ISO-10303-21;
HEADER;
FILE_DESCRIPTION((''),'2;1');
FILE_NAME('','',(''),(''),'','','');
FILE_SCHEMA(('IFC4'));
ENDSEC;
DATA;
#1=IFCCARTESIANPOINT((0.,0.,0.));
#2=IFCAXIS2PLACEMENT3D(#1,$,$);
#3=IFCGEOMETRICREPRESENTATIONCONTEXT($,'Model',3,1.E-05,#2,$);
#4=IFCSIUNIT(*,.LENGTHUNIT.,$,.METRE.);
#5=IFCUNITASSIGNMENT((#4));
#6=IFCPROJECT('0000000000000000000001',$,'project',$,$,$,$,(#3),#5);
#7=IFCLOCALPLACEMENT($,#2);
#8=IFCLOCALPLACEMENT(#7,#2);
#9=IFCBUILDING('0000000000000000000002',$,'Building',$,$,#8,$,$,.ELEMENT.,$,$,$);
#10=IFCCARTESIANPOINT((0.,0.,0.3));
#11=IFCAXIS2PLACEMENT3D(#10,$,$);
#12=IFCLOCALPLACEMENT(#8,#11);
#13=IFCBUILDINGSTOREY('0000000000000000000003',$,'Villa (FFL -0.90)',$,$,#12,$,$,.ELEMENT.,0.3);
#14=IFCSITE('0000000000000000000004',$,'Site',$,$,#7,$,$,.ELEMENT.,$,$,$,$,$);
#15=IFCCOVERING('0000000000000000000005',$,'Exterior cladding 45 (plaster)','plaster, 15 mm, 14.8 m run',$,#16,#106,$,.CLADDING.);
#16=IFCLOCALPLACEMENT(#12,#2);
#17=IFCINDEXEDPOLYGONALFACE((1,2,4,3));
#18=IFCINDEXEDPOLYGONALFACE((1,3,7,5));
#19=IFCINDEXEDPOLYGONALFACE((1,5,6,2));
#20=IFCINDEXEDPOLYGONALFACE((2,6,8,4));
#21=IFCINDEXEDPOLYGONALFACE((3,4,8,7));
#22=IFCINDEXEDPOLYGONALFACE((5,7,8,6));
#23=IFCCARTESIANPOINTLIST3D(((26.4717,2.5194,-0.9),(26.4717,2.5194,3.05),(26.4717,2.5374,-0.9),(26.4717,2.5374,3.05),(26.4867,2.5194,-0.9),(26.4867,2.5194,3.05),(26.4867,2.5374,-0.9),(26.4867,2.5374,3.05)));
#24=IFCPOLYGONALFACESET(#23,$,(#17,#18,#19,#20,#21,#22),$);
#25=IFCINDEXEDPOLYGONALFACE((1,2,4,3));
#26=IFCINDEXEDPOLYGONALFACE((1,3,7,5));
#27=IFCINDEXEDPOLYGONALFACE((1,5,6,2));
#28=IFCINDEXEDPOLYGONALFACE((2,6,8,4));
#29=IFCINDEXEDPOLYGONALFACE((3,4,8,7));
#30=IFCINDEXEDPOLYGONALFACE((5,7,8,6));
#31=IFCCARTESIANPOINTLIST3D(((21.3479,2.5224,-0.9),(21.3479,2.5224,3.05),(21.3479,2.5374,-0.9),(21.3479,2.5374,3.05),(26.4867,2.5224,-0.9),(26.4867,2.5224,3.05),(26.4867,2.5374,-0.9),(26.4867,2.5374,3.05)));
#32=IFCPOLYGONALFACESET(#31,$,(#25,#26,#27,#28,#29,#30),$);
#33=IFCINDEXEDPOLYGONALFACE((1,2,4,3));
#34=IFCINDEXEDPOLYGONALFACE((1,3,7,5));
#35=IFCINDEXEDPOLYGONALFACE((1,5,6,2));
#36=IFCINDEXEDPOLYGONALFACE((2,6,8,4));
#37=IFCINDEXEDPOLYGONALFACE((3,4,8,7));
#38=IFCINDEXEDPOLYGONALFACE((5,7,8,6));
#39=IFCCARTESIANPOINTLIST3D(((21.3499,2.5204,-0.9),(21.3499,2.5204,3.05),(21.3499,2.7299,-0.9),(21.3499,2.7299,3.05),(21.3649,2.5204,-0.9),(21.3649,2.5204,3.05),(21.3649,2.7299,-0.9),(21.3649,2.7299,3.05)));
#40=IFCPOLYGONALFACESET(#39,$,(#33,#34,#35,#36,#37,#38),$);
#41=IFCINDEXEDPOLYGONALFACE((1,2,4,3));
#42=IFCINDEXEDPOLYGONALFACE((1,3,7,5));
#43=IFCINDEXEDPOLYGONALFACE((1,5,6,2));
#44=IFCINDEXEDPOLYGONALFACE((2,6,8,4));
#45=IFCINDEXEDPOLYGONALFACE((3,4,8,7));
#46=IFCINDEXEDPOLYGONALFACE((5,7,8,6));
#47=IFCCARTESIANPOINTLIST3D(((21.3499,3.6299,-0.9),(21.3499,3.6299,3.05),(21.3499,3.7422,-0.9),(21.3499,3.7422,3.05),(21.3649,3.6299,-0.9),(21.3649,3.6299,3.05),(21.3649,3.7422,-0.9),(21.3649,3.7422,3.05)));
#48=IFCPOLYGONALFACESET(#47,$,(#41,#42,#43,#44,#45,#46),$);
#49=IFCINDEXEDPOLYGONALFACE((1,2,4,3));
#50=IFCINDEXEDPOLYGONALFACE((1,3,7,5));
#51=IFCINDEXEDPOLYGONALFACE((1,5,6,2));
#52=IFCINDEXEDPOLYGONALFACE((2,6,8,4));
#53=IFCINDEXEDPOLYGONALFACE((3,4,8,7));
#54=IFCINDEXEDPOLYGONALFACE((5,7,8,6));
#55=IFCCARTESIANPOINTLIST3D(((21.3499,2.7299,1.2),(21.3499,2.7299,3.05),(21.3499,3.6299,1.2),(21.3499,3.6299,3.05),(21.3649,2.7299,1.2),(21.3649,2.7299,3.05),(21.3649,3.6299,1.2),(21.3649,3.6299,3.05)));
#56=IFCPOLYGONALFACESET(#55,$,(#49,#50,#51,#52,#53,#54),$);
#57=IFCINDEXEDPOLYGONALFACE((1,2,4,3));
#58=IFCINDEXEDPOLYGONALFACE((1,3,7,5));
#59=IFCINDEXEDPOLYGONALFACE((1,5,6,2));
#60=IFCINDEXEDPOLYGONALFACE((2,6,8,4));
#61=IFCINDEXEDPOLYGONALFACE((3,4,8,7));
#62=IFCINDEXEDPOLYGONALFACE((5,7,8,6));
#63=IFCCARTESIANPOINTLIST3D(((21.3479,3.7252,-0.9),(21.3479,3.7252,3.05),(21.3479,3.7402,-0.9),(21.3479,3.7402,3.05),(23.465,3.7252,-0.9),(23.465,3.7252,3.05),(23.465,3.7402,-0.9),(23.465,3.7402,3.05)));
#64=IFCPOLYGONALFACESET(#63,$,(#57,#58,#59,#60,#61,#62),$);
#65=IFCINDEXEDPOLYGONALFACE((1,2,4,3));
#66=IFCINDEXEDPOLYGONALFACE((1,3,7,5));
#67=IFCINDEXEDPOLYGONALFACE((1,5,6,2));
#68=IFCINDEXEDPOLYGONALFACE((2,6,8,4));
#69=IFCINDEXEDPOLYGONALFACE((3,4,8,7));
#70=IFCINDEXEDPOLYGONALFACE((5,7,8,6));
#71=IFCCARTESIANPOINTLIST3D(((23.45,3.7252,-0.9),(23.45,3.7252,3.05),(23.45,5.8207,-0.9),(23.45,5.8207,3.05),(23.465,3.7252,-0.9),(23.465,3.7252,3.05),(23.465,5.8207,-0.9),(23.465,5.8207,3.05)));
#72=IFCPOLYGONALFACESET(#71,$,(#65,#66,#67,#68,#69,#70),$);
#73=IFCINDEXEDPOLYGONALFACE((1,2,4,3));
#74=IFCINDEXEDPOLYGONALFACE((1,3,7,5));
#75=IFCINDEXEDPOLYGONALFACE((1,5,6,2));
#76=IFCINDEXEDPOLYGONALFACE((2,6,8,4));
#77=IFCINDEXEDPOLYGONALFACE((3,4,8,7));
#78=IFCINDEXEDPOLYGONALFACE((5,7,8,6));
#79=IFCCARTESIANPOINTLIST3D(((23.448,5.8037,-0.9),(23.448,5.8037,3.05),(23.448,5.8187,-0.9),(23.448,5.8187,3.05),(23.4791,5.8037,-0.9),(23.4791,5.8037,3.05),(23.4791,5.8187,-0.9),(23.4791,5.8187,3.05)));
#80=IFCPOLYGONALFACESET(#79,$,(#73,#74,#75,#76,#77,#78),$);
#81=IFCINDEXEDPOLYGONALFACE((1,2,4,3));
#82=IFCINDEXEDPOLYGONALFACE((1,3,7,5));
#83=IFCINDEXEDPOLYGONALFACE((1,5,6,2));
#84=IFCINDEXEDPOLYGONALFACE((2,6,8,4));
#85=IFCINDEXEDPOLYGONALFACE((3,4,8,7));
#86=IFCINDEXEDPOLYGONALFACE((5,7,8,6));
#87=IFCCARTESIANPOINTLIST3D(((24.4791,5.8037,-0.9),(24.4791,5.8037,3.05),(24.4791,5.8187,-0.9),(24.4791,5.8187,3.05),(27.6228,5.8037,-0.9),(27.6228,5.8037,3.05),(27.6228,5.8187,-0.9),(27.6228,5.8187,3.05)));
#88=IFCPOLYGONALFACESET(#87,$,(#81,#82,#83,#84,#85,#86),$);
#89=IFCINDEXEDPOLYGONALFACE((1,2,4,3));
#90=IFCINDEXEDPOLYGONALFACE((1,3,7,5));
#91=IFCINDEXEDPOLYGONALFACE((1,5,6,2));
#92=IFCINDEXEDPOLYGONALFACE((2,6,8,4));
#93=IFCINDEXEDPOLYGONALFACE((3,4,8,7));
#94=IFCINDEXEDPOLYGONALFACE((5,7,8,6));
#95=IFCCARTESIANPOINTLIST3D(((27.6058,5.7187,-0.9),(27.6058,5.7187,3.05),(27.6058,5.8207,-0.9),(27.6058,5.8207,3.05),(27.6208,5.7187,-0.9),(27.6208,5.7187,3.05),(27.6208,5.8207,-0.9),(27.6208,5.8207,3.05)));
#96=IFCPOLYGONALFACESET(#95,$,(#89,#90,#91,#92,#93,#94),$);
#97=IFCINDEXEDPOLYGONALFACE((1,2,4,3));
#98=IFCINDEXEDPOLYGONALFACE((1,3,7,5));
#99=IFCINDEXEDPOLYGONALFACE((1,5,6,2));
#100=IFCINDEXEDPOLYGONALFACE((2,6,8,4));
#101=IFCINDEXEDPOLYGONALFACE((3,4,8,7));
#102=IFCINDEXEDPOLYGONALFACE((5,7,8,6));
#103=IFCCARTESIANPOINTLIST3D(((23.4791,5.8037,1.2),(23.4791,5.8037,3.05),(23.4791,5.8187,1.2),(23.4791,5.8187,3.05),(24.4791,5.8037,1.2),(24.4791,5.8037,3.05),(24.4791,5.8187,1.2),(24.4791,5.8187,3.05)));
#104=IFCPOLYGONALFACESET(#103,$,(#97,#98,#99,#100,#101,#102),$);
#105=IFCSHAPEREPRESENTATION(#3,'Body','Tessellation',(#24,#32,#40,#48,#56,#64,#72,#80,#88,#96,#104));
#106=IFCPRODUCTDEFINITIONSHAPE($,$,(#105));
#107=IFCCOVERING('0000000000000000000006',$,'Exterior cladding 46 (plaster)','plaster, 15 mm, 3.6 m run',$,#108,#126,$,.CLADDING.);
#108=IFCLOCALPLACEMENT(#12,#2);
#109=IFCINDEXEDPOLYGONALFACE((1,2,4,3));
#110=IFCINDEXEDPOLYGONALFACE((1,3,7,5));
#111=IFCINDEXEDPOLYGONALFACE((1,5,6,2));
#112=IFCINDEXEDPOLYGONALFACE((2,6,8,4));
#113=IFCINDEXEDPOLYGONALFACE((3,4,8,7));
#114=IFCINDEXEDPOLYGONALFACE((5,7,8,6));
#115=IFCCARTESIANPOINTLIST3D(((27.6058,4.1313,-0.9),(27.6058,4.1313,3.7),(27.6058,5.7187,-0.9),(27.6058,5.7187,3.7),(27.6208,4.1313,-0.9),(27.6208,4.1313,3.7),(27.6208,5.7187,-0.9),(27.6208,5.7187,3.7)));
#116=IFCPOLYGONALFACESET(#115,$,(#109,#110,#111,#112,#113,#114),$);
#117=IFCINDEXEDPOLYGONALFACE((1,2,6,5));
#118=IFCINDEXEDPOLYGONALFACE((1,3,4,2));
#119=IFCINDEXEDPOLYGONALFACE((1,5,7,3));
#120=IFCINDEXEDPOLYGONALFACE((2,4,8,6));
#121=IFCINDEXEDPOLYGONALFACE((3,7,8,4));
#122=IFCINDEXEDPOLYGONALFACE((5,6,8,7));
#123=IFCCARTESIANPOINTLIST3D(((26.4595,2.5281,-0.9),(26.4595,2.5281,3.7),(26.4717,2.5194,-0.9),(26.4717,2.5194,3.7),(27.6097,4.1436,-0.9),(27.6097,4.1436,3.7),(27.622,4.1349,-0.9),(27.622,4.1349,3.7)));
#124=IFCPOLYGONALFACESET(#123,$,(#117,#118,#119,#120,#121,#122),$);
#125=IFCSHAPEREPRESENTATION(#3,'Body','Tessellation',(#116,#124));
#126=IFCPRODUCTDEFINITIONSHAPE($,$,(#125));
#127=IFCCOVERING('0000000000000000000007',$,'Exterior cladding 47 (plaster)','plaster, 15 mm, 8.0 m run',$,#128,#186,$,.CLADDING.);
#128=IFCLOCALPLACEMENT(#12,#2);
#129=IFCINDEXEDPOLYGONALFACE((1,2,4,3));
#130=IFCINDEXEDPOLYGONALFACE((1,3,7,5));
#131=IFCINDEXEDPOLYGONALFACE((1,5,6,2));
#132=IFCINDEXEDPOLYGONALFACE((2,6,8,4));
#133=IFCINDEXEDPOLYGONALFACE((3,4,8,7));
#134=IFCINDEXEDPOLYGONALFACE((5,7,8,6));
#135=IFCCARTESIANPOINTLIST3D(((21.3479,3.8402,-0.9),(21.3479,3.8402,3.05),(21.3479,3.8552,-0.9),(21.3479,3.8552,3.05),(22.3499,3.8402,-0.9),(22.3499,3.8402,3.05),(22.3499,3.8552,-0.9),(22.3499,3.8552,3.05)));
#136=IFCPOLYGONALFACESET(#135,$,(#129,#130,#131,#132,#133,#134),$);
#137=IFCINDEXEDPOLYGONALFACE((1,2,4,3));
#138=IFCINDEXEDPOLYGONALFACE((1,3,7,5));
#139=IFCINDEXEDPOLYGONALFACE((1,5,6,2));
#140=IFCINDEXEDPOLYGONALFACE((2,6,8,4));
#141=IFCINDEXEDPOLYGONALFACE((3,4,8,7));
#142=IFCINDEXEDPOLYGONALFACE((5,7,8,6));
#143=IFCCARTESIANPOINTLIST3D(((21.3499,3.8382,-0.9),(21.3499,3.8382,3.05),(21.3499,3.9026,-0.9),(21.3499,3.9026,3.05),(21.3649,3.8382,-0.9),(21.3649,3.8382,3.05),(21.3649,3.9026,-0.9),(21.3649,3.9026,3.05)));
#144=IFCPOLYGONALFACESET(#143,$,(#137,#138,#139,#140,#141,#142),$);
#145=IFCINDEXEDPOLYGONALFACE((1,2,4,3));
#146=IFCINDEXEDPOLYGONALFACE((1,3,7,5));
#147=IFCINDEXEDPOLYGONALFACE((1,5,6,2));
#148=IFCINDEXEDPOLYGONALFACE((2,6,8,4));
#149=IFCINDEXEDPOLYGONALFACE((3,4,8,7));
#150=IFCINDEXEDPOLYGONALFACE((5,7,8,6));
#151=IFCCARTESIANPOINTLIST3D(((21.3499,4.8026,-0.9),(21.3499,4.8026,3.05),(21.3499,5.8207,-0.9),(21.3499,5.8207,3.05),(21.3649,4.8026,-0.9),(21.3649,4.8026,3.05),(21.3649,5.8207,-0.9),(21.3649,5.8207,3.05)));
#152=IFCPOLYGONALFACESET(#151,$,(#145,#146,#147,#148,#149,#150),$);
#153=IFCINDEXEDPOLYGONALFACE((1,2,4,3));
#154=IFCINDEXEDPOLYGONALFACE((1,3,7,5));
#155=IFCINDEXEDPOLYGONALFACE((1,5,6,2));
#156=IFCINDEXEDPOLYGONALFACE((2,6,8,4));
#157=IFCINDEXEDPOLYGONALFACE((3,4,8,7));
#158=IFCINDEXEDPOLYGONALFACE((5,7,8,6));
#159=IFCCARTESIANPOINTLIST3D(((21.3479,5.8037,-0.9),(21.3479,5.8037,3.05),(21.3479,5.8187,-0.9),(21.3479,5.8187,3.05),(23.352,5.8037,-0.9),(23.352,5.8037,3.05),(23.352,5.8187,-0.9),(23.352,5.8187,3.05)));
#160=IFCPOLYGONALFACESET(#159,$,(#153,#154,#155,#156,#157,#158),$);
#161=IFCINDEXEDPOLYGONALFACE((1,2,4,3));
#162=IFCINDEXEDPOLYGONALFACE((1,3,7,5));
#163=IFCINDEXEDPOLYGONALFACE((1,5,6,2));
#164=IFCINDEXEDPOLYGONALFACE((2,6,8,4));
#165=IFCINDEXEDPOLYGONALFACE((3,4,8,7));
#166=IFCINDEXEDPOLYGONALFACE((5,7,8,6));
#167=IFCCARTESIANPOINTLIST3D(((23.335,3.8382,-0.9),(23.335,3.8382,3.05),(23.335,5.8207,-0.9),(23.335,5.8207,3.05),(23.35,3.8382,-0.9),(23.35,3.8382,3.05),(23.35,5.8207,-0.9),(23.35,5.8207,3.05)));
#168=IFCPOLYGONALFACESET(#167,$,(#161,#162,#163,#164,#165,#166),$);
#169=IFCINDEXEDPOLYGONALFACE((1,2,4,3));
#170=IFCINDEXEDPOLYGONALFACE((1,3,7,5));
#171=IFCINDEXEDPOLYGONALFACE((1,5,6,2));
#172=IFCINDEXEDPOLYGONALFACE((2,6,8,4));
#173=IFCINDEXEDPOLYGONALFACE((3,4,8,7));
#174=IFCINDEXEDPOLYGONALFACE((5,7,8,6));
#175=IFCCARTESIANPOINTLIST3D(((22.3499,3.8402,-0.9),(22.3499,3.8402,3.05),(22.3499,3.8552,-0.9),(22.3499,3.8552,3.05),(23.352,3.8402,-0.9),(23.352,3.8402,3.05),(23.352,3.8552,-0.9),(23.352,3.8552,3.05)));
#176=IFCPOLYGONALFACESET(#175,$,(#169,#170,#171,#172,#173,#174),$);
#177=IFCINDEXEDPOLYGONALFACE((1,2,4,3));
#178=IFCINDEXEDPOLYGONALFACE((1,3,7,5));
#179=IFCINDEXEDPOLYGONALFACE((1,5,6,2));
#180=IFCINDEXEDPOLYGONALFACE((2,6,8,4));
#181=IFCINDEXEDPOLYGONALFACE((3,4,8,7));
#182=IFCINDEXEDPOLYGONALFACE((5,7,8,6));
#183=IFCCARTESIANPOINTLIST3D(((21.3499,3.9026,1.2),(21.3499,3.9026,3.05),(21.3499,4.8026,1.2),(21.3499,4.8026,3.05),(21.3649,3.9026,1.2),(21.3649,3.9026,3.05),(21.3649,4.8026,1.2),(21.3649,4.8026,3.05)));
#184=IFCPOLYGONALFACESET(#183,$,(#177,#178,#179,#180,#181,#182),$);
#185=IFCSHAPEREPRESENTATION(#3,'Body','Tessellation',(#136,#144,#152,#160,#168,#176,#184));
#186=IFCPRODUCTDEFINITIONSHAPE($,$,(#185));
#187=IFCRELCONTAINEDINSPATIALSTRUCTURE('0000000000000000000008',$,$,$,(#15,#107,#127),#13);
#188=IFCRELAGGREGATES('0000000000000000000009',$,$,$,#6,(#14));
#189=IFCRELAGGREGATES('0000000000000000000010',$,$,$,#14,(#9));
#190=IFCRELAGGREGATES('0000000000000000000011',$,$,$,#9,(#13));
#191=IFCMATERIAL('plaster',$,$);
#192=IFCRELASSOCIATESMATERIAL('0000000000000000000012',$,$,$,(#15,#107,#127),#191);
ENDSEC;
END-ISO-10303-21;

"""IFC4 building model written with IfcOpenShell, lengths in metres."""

from ifc_helpers import new_model, si_unit, frame, origin, origin_with_axes, place, context, project, spatial, polyline, outline, extrude, material, element, save


model = new_model("IFC4")

# Units and contexts
model_context = context("Model", 3, precision=1e-05, world=origin())
ifc_project = project(units=[si_unit("LENGTHUNIT", "METRE")], contexts=[model_context])

# Site, building, storey
site_placement = place(None, origin())
site = spatial("IfcSite", under=ifc_project, at=site_placement, Name="Site", CompositionType="ELEMENT")
building_placement = place(site_placement, origin())
building = spatial("IfcBuilding", under=site, at=building_placement, Name="Building", CompositionType="ELEMENT")
storey_placement = place(building_placement, frame((0.0, 0.0, 0.3)))
storey = spatial("IfcBuildingStorey", under=building, at=storey_placement, Name="Villa (FFL -0.90)", CompositionType="ELEMENT", Elevation=0.3)

# Coverings
ifc_material = material(Name="plaster")
covering_1_placement = place(storey_placement, origin_with_axes())
element("IfcCovering", 1, at=covering_1_placement, inside=storey, material=ifc_material, Name="Exterior cladding 45 (plaster)", Description="plaster, 15 mm, 14.8 m run", PredefinedType="CLADDING", context=model_context, shape_type="SweptSolid", body=[
    extrude(outline(polyline([(26.4867, 2.5194), (26.4867, 2.5374), (26.4717, 2.5374), (26.4717, 2.5194), (26.4867, 2.5194)])), frame((0.0, 0.0, -0.9)), (0.0, 0.0, 1.0), 3.95),
    extrude(outline(polyline([(26.4867, 2.5374), (21.3479, 2.5374), (21.3479, 2.5224), (26.4867, 2.5224), (26.4867, 2.5374)])), frame((0.0, 0.0, -0.9)), (0.0, 0.0, 1.0), 3.95),
    extrude(outline(polyline([(21.3649, 2.5204), (21.3649, 2.7299), (21.3499, 2.7299), (21.3499, 2.5204), (21.3649, 2.5204)])), frame((0.0, 0.0, -0.9)), (0.0, 0.0, 1.0), 3.95),
    extrude(outline(polyline([(21.3649, 3.6299), (21.3649, 3.7422), (21.3499, 3.7422), (21.3499, 3.6299), (21.3649, 3.6299)])), frame((0.0, 0.0, -0.9)), (0.0, 0.0, 1.0), 3.95),
    extrude(outline(polyline([(21.3649, 2.7299), (21.3649, 3.6299), (21.3499, 3.6299), (21.3499, 2.7299), (21.3649, 2.7299)])), frame((0.0, 0.0, 1.2)), (0.0, 0.0, 1.0), 1.85),
    extrude(outline(polyline([(21.3479, 3.7252), (23.465, 3.7252), (23.465, 3.7401), (21.3479, 3.7401), (21.3479, 3.7252)])), frame((0.0, 0.0, -0.9)), (0.0, 0.0, 1.0), 3.95),
    extrude(outline(polyline([(23.465, 3.7252), (23.465, 5.8207), (23.45, 5.8207), (23.45, 3.7252), (23.465, 3.7252)])), frame((0.0, 0.0, -0.9)), (0.0, 0.0, 1.0), 3.95),
    extrude(outline(polyline([(23.448, 5.8037), (23.4791, 5.8037), (23.4791, 5.8187), (23.448, 5.8187), (23.448, 5.8037)])), frame((0.0, 0.0, -0.9)), (0.0, 0.0, 1.0), 3.95),
    extrude(outline(polyline([(24.4791, 5.8037), (27.6228, 5.8037), (27.6228, 5.8187), (24.4791, 5.8187), (24.4791, 5.8037)])), frame((0.0, 0.0, -0.9)), (0.0, 0.0, 1.0), 3.95),
    extrude(outline(polyline([(27.6058, 5.8207), (27.6058, 5.7187), (27.6208, 5.7187), (27.6208, 5.8207), (27.6058, 5.8207)])), frame((0.0, 0.0, -0.9)), (0.0, 0.0, 1.0), 3.95),
    extrude(outline(polyline([(23.4791, 5.8037), (24.4791, 5.8037), (24.4791, 5.8187), (23.4791, 5.8187), (23.4791, 5.8037)])), frame((0.0, 0.0, 1.2)), (0.0, 0.0, 1.0), 1.85),
])
covering_2_placement = place(storey_placement, origin_with_axes())
element("IfcCovering", 2, at=covering_2_placement, inside=storey, material=ifc_material, Name="Exterior cladding 46 (plaster)", Description="plaster, 15 mm, 3.6 m run", PredefinedType="CLADDING", context=model_context, shape_type="SweptSolid", body=[
    extrude(outline(polyline([(27.6058, 5.7187), (27.6058, 4.1313), (27.6208, 4.1313), (27.6208, 5.7187), (27.6058, 5.7187)])), frame((0.0, 0.0, -0.9)), (0.0, 0.0, 1.0), 4.6),
    extrude(outline(polyline([(27.6097, 4.1436), (26.4595, 2.5281), (26.4717, 2.5194), (27.622, 4.1349), (27.6097, 4.1436)])), frame((0.0, 0.0, -0.9)), (0.0, 0.0, 1.0), 4.6),
])
covering_3_placement = place(storey_placement, origin_with_axes())
element("IfcCovering", 3, at=covering_3_placement, inside=storey, material=ifc_material, Name="Exterior cladding 47 (plaster)", Description="plaster, 15 mm, 8.0 m run", PredefinedType="CLADDING", context=model_context, shape_type="SweptSolid", body=[
    extrude(outline(polyline([(22.3499, 3.8552), (21.3479, 3.8552), (21.3479, 3.8401), (22.3499, 3.8401), (22.3499, 3.8552)])), frame((0.0, 0.0, -0.9)), (0.0, 0.0, 1.0), 3.95),
    extrude(outline(polyline([(21.3649, 3.8382), (21.3649, 3.9026), (21.3499, 3.9026), (21.3499, 3.8382), (21.3649, 3.8382)])), frame((0.0, 0.0, -0.9)), (0.0, 0.0, 1.0), 3.95),
    extrude(outline(polyline([(21.3649, 4.8026), (21.3649, 5.8207), (21.3499, 5.8207), (21.3499, 4.8026), (21.3649, 4.8026)])), frame((0.0, 0.0, -0.9)), (0.0, 0.0, 1.0), 3.95),
    extrude(outline(polyline([(21.3479, 5.8037), (23.352, 5.8037), (23.352, 5.8187), (21.3479, 5.8187), (21.3479, 5.8037)])), frame((0.0, 0.0, -0.9)), (0.0, 0.0, 1.0), 3.95),
    extrude(outline(polyline([(23.335, 5.8207), (23.335, 3.8382), (23.35, 3.8382), (23.35, 5.8207), (23.335, 5.8207)])), frame((0.0, 0.0, -0.9)), (0.0, 0.0, 1.0), 3.95),
    extrude(outline(polyline([(23.352, 3.8552), (22.3499, 3.8552), (22.3499, 3.8401), (23.352, 3.8401), (23.352, 3.8552)])), frame((0.0, 0.0, -0.9)), (0.0, 0.0, 1.0), 3.95),
    extrude(outline(polyline([(21.3649, 3.9026), (21.3649, 4.8026), (21.3499, 4.8026), (21.3499, 3.9026), (21.3649, 3.9026)])), frame((0.0, 0.0, 1.2)), (0.0, 0.0, 1.0), 1.85),
])

save(model, "model.ifc")
